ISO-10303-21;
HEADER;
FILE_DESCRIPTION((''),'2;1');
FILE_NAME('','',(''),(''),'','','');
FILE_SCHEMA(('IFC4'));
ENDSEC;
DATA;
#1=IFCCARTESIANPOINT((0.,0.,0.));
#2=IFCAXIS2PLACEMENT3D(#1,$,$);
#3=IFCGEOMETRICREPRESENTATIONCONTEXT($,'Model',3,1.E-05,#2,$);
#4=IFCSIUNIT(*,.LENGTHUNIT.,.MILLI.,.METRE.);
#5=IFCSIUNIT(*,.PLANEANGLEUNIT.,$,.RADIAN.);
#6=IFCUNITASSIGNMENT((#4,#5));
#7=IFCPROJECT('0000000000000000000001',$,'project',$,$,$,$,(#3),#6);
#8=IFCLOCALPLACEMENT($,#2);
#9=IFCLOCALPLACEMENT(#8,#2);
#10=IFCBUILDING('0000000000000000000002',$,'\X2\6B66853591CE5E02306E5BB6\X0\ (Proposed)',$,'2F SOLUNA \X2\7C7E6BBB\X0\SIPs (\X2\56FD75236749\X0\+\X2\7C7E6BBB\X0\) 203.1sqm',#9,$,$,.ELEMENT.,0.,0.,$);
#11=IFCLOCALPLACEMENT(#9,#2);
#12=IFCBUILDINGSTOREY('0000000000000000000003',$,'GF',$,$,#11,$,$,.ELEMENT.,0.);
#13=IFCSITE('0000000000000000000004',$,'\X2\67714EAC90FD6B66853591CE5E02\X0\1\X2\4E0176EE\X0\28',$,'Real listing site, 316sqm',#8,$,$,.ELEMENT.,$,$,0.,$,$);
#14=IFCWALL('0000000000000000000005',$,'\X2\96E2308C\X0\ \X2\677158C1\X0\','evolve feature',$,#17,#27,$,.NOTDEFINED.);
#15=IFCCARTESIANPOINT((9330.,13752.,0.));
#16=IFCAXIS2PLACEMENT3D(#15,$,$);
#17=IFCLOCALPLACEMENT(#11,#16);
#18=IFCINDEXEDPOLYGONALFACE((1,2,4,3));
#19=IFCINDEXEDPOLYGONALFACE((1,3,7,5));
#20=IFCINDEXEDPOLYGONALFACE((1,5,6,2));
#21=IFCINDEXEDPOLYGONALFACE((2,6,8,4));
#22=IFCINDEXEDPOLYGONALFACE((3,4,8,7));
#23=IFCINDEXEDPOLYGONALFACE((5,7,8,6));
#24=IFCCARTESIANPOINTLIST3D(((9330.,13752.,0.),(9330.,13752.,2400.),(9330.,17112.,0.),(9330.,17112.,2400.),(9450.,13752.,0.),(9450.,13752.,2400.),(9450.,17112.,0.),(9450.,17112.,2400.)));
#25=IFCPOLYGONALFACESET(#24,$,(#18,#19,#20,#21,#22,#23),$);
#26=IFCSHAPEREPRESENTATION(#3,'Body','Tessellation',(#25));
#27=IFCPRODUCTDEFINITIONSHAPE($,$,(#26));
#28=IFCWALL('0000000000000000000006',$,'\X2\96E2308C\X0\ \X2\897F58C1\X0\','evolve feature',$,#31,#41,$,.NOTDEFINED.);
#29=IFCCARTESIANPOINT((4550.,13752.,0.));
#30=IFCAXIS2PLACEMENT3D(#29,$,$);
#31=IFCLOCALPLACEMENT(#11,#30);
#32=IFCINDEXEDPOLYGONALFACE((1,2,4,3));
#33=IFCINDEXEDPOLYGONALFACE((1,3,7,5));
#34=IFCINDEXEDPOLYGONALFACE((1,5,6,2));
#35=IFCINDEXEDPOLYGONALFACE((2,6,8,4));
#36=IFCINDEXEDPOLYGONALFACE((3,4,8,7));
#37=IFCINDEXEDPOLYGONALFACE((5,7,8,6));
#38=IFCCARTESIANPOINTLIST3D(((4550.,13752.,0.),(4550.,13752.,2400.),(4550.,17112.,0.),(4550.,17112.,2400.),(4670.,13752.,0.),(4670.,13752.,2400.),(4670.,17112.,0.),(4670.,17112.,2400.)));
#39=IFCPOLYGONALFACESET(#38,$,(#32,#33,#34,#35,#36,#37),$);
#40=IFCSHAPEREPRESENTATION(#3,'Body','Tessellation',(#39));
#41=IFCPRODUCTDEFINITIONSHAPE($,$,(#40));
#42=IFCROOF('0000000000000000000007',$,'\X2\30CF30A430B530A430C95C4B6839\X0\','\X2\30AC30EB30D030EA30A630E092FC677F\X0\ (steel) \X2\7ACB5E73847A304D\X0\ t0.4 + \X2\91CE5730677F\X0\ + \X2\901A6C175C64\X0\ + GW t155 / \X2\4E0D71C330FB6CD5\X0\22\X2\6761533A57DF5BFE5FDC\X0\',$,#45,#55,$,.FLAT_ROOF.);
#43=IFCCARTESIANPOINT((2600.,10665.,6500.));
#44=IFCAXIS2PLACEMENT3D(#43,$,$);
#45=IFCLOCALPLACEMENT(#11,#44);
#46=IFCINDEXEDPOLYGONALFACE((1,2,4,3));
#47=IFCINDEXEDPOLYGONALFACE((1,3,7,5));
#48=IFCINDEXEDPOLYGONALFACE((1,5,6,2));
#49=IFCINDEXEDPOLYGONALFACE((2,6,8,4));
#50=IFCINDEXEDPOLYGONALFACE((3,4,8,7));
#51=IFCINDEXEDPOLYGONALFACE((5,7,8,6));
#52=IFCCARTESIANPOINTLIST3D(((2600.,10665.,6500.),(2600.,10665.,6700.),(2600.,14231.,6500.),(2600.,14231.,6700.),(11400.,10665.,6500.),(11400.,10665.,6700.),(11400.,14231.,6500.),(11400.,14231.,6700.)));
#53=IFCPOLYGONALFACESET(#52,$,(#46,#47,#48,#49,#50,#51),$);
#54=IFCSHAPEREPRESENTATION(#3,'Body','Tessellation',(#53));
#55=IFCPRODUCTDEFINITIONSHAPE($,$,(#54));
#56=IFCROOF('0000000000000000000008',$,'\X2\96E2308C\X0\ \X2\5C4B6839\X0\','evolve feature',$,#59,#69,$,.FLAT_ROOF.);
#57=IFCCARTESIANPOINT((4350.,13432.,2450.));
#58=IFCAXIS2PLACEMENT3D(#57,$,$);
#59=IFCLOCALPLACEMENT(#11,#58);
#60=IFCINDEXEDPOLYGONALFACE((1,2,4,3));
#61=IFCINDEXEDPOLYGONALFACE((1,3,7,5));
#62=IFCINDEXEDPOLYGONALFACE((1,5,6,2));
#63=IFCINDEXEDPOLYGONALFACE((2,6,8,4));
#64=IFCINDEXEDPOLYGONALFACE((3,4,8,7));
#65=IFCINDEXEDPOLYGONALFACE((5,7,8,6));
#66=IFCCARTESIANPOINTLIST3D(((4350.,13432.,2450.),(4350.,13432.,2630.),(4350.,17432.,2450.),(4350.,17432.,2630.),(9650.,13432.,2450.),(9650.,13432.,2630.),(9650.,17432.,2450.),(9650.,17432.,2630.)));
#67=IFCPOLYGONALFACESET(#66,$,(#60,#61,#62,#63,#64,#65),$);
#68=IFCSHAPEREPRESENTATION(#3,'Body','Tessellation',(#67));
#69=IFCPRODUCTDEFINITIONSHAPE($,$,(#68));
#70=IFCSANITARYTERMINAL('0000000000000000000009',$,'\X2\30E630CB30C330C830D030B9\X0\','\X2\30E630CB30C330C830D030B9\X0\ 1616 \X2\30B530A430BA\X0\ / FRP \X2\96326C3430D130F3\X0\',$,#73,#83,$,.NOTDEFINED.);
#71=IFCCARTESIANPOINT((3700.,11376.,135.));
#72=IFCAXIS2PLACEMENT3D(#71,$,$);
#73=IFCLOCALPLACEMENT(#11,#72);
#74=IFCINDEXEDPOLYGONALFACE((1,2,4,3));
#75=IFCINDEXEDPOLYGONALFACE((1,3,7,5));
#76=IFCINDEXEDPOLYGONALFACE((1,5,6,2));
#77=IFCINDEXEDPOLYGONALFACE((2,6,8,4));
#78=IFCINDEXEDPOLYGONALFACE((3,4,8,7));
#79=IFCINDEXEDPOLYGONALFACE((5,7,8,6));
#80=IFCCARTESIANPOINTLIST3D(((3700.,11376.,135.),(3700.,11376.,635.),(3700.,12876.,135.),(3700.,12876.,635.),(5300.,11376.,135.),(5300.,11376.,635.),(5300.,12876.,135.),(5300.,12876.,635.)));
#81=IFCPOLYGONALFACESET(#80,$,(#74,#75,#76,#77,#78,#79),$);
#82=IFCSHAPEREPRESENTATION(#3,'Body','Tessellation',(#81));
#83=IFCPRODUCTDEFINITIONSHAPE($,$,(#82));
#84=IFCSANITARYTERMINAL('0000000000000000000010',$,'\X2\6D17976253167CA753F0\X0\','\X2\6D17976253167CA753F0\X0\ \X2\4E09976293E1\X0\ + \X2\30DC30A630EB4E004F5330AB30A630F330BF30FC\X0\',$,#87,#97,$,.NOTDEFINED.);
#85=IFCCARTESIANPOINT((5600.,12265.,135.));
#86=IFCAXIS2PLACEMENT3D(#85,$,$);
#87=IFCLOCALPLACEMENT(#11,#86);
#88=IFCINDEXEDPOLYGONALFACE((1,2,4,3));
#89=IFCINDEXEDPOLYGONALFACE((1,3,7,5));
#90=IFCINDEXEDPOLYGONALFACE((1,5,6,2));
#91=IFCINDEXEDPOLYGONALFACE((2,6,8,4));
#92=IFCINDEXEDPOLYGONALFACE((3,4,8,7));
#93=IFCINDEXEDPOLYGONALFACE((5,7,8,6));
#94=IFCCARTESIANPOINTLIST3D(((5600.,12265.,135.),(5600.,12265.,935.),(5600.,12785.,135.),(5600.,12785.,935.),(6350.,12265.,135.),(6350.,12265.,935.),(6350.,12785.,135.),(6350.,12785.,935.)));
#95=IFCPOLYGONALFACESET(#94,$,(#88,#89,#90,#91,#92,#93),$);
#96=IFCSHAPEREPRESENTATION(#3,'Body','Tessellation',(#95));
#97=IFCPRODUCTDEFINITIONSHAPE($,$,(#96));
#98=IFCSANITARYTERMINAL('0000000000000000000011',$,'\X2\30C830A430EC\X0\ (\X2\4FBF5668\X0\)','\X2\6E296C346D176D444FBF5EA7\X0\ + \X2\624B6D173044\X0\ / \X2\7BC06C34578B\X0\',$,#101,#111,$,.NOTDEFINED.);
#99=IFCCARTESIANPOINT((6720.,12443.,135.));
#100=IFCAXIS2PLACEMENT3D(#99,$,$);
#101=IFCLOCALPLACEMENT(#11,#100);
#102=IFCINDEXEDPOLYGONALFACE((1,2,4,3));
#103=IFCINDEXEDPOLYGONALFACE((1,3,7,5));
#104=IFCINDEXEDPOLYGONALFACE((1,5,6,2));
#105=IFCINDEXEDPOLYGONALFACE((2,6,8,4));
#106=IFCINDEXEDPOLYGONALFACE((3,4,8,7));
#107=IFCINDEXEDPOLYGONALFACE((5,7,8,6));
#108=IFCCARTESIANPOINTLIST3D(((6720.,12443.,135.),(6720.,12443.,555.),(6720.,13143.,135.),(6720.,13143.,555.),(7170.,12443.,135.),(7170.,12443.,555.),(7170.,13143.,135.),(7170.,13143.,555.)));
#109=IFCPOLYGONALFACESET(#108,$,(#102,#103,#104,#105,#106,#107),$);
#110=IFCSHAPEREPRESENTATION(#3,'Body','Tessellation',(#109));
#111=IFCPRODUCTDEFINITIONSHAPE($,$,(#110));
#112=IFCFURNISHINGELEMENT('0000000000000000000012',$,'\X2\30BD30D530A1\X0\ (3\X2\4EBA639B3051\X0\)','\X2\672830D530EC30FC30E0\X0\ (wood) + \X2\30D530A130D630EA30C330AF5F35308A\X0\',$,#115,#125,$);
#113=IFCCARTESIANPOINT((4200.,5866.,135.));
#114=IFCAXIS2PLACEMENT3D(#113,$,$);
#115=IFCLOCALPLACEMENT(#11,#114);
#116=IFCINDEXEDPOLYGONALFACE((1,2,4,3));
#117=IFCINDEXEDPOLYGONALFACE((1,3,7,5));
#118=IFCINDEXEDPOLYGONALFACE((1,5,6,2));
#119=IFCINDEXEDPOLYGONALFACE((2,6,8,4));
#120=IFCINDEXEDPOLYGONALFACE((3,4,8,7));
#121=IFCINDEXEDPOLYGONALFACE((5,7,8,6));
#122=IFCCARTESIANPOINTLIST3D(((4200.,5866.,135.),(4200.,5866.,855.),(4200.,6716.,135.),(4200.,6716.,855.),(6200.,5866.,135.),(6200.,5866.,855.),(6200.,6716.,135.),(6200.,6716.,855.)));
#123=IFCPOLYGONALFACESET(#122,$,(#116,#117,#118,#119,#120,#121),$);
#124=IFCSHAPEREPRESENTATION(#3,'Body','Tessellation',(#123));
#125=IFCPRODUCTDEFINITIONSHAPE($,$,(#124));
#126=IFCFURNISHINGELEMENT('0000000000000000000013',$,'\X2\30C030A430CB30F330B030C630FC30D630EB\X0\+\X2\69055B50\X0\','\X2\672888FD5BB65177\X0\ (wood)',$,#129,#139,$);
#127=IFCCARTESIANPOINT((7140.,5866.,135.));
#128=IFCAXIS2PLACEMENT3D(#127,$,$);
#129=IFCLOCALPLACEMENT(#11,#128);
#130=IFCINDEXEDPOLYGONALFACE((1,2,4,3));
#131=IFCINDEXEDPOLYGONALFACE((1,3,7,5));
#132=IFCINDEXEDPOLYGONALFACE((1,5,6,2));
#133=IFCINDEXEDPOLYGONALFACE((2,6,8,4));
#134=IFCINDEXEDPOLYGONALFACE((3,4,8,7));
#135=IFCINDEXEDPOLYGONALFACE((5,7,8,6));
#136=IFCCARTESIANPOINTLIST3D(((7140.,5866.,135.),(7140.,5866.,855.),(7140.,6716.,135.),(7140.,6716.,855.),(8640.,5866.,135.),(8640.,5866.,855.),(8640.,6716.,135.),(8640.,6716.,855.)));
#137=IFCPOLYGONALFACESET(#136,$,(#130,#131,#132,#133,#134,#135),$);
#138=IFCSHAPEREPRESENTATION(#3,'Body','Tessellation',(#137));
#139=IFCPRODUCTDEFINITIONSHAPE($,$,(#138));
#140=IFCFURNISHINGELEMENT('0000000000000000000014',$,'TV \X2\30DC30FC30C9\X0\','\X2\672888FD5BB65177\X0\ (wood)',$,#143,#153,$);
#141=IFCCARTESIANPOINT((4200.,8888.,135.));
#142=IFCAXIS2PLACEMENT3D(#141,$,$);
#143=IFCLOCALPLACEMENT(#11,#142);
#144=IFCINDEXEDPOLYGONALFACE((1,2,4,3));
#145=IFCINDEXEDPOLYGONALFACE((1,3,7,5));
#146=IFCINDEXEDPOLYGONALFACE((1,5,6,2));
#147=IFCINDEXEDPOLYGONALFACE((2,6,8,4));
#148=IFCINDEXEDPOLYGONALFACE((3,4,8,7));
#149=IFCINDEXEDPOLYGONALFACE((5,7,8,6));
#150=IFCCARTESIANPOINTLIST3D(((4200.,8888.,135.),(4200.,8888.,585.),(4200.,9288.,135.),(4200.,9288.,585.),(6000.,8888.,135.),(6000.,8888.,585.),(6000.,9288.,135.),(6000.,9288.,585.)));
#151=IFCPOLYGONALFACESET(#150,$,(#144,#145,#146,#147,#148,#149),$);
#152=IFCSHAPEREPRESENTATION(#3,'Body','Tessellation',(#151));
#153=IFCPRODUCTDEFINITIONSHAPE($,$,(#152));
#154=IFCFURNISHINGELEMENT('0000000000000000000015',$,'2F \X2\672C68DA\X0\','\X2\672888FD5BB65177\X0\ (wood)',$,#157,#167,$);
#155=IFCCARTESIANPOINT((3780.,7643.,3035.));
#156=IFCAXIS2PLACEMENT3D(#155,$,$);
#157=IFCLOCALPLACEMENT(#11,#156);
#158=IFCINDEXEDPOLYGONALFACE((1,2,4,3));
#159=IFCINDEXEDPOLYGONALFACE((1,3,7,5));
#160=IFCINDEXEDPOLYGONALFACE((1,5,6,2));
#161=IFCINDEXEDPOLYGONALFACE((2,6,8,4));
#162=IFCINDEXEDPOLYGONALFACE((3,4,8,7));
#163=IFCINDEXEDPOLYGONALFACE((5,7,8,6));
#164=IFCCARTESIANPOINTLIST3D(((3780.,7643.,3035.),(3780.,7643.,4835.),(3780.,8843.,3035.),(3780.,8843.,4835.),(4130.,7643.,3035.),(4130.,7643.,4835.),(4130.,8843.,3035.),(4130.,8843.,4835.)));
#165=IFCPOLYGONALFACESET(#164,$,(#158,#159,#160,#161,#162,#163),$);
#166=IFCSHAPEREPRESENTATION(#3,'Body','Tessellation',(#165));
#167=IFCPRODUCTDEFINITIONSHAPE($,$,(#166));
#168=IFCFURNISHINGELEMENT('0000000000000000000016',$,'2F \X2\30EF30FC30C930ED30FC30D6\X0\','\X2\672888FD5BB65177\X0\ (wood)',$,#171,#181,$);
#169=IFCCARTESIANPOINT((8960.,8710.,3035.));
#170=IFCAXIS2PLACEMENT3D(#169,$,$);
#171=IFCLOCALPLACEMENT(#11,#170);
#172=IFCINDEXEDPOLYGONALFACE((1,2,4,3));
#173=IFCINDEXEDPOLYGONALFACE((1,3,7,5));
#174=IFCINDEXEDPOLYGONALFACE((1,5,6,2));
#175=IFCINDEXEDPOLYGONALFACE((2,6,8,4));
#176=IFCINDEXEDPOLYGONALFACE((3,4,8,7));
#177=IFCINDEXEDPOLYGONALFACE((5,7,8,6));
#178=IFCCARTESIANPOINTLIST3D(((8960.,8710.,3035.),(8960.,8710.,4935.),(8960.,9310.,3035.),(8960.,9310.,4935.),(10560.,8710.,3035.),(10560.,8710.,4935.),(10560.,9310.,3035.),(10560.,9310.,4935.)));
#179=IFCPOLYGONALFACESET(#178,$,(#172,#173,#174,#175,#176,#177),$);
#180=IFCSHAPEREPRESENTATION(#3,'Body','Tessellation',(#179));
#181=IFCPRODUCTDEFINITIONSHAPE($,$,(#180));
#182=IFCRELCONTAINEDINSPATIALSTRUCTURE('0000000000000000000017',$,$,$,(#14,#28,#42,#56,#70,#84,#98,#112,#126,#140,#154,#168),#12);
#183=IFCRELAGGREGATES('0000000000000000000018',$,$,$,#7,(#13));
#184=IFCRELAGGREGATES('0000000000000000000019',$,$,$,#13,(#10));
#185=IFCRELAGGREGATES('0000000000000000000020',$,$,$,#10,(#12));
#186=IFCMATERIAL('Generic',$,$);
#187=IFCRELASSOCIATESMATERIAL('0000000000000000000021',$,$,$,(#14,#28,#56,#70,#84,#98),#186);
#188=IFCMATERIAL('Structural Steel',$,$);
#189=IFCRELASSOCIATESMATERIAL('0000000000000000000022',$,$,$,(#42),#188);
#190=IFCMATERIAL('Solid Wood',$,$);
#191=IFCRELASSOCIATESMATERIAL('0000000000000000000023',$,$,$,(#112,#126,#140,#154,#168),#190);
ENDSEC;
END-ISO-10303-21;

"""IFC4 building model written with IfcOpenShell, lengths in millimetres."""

from ifc_helpers import new_model, si_unit, frame, frame_2d, origin, place, context, project, spatial, rectangle, extrude, material, element, save


model = new_model("IFC4")

# Units and contexts
model_context = context("Model", 3, precision=1e-05, world=origin())
ifc_project = project(units=[si_unit("LENGTHUNIT", "METRE", prefix="MILLI"), si_unit("PLANEANGLEUNIT", "RADIAN")], contexts=[model_context])

# Site, building, storey
site_placement = place(None, origin())
site = spatial("IfcSite", under=ifc_project, at=site_placement, Name="東京都武蔵野市1丁目28", ObjectType="Real listing site, 316sqm", CompositionType="ELEMENT", RefElevation=0.0)
building_placement = place(site_placement, origin())
building = spatial("IfcBuilding", under=site, at=building_placement, Name="武蔵野市の家 (Proposed)", ObjectType="2F SOLUNA 籾殻SIPs (国産杉+籾殻) 203.1sqm", CompositionType="ELEMENT", ElevationOfRefHeight=0.0, ElevationOfTerrain=0.0)
storey_placement = place(building_placement, origin())
storey = spatial("IfcBuildingStorey", under=building, at=storey_placement, Name="GF", CompositionType="ELEMENT", Elevation=0.0)

# Shared definitions
ifc_material_1 = material(Name="Generic")

# Shared definitions
ifc_material_2 = material(Name="Solid Wood")

# Walls
wall_1_placement = place(storey_placement, frame((9330.0, 13752.0, 0.0)))
element("IfcWall", 1, at=wall_1_placement, inside=storey, material=ifc_material_1, Name="離れ 東壁", Description="evolve feature", PredefinedType="NOTDEFINED", context=model_context, shape_type="SweptSolid", body=[
    extrude(rectangle(XDim=120.0, YDim=3360.0, at=frame_2d((60.0, 1680.0))), frame((9330.0, 13752.0, 0.0)), (0.0, 0.0, 1.0), 2400.0),
])
wall_2_placement = place(storey_placement, frame((4550.0, 13752.0, 0.0)))
element("IfcWall", 2, at=wall_2_placement, inside=storey, material=ifc_material_1, Name="離れ 西壁", Description="evolve feature", PredefinedType="NOTDEFINED", context=model_context, shape_type="SweptSolid", body=[
    extrude(rectangle(XDim=120.0, YDim=3360.0, at=frame_2d((60.0, 1680.0))), frame((4550.0, 13752.0, 0.0)), (0.0, 0.0, 1.0), 2400.0),
])

# Roofs
ifc_material_3 = material(Name="Structural Steel")
roof_1_placement = place(storey_placement, frame((2600.0, 10665.0, 6500.0)))
element("IfcRoof", 3, at=roof_1_placement, inside=storey, material=ifc_material_3, Name="ハイサイド屋根", Description="ガルバリウム鋼板 (steel) 立平葺き t0.4 + 野地板 + 通気層 + GW t155 / 不燃・法22条区域対応", PredefinedType="FLAT_ROOF", context=model_context, shape_type="SweptSolid", body=[
    extrude(rectangle(XDim=8800.0, YDim=3566.0, at=frame_2d((4400.0, 1783.0))), frame((2600.0, 10665.0, 6500.0)), (0.0, 0.0, 1.0), 200.0),
])
roof_2_placement = place(storey_placement, frame((4350.0, 13432.0, 2450.0)))
element("IfcRoof", 4, at=roof_2_placement, inside=storey, material=ifc_material_1, Name="離れ 屋根", Description="evolve feature", PredefinedType="FLAT_ROOF", context=model_context, shape_type="SweptSolid", body=[
    extrude(rectangle(XDim=5300.0, YDim=4000.0, at=frame_2d((2650.0, 2000.0))), frame((4350.0, 13432.0, 2450.0)), (0.0, 0.0, 1.0), 180.0),
])

# Sanitary terminals
sanitary_terminal_1_placement = place(storey_placement, frame((3700.0, 11376.0, 135.0)))
element("IfcSanitaryTerminal", 5, at=sanitary_terminal_1_placement, inside=storey, material=ifc_material_1, Name="ユニットバス", Description="ユニットバス 1616 サイズ / FRP 防水パン", PredefinedType="NOTDEFINED", context=model_context, shape_type="SweptSolid", body=[
    extrude(rectangle(XDim=1600.0, YDim=1500.0, at=frame_2d((800.0, 750.0))), frame((3700.0, 11376.0, 135.0)), (0.0, 0.0, 1.0), 500.0),
])
sanitary_terminal_2_placement = place(storey_placement, frame((5600.0, 12265.0, 135.0)))
element("IfcSanitaryTerminal", 6, at=sanitary_terminal_2_placement, inside=storey, material=ifc_material_1, Name="洗面化粧台", Description="洗面化粧台 三面鏡 + ボウル一体カウンター", PredefinedType="NOTDEFINED", context=model_context, shape_type="SweptSolid", body=[
    extrude(rectangle(XDim=750.0, YDim=520.0, at=frame_2d((375.0, 260.0))), frame((5600.0, 12265.0, 135.0)), (0.0, 0.0, 1.0), 800.0),
])
sanitary_terminal_3_placement = place(storey_placement, frame((6720.0, 12443.0, 135.0)))
element("IfcSanitaryTerminal", 7, at=sanitary_terminal_3_placement, inside=storey, material=ifc_material_1, Name="トイレ (便器)", Description="温水洗浄便座 + 手洗い / 節水型", PredefinedType="NOTDEFINED", context=model_context, shape_type="SweptSolid", body=[
    extrude(rectangle(XDim=450.0, YDim=700.0, at=frame_2d((225.0, 350.0))), frame((6720.0, 12443.0, 135.0)), (0.0, 0.0, 1.0), 420.0),
])

# Furnishing elements
furnishing_1_placement = place(storey_placement, frame((4200.0, 5866.0, 135.0)))
element("IfcFurnishingElement", 8, at=furnishing_1_placement, inside=storey, material=ifc_material_2, Name="ソファ (3人掛け)", Description="木フレーム (wood) + ファブリック張り", context=model_context, shape_type="SweptSolid", body=[
    extrude(rectangle(XDim=2000.0, YDim=850.0, at=frame_2d((1000.0, 425.0))), frame((4200.0, 5866.0, 135.0)), (0.0, 0.0, 1.0), 720.0),
])
furnishing_2_placement = place(storey_placement, frame((7140.0, 5866.0, 135.0)))
element("IfcFurnishingElement", 9, at=furnishing_2_placement, inside=storey, material=ifc_material_2, Name="ダイニングテーブル+椅子", Description="木製家具 (wood)", context=model_context, shape_type="SweptSolid", body=[
    extrude(rectangle(XDim=1500.0, YDim=850.0, at=frame_2d((750.0, 425.0))), frame((7140.0, 5866.0, 135.0)), (0.0, 0.0, 1.0), 720.0),
])
furnishing_3_placement = place(storey_placement, frame((4200.0, 8888.0, 135.0)))
element("IfcFurnishingElement", 10, at=furnishing_3_placement, inside=storey, material=ifc_material_2, Name="TV ボード", Description="木製家具 (wood)", context=model_context, shape_type="SweptSolid", body=[
    extrude(rectangle(XDim=1800.0, YDim=400.0, at=frame_2d((900.0, 200.0))), frame((4200.0, 8888.0, 135.0)), (0.0, 0.0, 1.0), 450.0),
])
furnishing_4_placement = place(storey_placement, frame((3780.0, 7643.0, 3035.0)))
element("IfcFurnishingElement", 11, at=furnishing_4_placement, inside=storey, material=ifc_material_2, Name="2F 本棚", Description="木製家具 (wood)", context=model_context, shape_type="SweptSolid", body=[
    extrude(rectangle(XDim=350.0, YDim=1200.0, at=frame_2d((175.0, 600.0))), frame((3780.0, 7643.0, 3035.0)), (0.0, 0.0, 1.0), 1800.0),
])
furnishing_5_placement = place(storey_placement, frame((8960.0, 8710.0, 3035.0)))
element("IfcFurnishingElement", 12, at=furnishing_5_placement, inside=storey, material=ifc_material_2, Name="2F ワードローブ", Description="木製家具 (wood)", context=model_context, shape_type="SweptSolid", body=[
    extrude(rectangle(XDim=1600.0, YDim=600.0, at=frame_2d((800.0, 300.0))), frame((8960.0, 8710.0, 3035.0)), (0.0, 0.0, 1.0), 1900.0),
])

save(model, "model.ifc")
